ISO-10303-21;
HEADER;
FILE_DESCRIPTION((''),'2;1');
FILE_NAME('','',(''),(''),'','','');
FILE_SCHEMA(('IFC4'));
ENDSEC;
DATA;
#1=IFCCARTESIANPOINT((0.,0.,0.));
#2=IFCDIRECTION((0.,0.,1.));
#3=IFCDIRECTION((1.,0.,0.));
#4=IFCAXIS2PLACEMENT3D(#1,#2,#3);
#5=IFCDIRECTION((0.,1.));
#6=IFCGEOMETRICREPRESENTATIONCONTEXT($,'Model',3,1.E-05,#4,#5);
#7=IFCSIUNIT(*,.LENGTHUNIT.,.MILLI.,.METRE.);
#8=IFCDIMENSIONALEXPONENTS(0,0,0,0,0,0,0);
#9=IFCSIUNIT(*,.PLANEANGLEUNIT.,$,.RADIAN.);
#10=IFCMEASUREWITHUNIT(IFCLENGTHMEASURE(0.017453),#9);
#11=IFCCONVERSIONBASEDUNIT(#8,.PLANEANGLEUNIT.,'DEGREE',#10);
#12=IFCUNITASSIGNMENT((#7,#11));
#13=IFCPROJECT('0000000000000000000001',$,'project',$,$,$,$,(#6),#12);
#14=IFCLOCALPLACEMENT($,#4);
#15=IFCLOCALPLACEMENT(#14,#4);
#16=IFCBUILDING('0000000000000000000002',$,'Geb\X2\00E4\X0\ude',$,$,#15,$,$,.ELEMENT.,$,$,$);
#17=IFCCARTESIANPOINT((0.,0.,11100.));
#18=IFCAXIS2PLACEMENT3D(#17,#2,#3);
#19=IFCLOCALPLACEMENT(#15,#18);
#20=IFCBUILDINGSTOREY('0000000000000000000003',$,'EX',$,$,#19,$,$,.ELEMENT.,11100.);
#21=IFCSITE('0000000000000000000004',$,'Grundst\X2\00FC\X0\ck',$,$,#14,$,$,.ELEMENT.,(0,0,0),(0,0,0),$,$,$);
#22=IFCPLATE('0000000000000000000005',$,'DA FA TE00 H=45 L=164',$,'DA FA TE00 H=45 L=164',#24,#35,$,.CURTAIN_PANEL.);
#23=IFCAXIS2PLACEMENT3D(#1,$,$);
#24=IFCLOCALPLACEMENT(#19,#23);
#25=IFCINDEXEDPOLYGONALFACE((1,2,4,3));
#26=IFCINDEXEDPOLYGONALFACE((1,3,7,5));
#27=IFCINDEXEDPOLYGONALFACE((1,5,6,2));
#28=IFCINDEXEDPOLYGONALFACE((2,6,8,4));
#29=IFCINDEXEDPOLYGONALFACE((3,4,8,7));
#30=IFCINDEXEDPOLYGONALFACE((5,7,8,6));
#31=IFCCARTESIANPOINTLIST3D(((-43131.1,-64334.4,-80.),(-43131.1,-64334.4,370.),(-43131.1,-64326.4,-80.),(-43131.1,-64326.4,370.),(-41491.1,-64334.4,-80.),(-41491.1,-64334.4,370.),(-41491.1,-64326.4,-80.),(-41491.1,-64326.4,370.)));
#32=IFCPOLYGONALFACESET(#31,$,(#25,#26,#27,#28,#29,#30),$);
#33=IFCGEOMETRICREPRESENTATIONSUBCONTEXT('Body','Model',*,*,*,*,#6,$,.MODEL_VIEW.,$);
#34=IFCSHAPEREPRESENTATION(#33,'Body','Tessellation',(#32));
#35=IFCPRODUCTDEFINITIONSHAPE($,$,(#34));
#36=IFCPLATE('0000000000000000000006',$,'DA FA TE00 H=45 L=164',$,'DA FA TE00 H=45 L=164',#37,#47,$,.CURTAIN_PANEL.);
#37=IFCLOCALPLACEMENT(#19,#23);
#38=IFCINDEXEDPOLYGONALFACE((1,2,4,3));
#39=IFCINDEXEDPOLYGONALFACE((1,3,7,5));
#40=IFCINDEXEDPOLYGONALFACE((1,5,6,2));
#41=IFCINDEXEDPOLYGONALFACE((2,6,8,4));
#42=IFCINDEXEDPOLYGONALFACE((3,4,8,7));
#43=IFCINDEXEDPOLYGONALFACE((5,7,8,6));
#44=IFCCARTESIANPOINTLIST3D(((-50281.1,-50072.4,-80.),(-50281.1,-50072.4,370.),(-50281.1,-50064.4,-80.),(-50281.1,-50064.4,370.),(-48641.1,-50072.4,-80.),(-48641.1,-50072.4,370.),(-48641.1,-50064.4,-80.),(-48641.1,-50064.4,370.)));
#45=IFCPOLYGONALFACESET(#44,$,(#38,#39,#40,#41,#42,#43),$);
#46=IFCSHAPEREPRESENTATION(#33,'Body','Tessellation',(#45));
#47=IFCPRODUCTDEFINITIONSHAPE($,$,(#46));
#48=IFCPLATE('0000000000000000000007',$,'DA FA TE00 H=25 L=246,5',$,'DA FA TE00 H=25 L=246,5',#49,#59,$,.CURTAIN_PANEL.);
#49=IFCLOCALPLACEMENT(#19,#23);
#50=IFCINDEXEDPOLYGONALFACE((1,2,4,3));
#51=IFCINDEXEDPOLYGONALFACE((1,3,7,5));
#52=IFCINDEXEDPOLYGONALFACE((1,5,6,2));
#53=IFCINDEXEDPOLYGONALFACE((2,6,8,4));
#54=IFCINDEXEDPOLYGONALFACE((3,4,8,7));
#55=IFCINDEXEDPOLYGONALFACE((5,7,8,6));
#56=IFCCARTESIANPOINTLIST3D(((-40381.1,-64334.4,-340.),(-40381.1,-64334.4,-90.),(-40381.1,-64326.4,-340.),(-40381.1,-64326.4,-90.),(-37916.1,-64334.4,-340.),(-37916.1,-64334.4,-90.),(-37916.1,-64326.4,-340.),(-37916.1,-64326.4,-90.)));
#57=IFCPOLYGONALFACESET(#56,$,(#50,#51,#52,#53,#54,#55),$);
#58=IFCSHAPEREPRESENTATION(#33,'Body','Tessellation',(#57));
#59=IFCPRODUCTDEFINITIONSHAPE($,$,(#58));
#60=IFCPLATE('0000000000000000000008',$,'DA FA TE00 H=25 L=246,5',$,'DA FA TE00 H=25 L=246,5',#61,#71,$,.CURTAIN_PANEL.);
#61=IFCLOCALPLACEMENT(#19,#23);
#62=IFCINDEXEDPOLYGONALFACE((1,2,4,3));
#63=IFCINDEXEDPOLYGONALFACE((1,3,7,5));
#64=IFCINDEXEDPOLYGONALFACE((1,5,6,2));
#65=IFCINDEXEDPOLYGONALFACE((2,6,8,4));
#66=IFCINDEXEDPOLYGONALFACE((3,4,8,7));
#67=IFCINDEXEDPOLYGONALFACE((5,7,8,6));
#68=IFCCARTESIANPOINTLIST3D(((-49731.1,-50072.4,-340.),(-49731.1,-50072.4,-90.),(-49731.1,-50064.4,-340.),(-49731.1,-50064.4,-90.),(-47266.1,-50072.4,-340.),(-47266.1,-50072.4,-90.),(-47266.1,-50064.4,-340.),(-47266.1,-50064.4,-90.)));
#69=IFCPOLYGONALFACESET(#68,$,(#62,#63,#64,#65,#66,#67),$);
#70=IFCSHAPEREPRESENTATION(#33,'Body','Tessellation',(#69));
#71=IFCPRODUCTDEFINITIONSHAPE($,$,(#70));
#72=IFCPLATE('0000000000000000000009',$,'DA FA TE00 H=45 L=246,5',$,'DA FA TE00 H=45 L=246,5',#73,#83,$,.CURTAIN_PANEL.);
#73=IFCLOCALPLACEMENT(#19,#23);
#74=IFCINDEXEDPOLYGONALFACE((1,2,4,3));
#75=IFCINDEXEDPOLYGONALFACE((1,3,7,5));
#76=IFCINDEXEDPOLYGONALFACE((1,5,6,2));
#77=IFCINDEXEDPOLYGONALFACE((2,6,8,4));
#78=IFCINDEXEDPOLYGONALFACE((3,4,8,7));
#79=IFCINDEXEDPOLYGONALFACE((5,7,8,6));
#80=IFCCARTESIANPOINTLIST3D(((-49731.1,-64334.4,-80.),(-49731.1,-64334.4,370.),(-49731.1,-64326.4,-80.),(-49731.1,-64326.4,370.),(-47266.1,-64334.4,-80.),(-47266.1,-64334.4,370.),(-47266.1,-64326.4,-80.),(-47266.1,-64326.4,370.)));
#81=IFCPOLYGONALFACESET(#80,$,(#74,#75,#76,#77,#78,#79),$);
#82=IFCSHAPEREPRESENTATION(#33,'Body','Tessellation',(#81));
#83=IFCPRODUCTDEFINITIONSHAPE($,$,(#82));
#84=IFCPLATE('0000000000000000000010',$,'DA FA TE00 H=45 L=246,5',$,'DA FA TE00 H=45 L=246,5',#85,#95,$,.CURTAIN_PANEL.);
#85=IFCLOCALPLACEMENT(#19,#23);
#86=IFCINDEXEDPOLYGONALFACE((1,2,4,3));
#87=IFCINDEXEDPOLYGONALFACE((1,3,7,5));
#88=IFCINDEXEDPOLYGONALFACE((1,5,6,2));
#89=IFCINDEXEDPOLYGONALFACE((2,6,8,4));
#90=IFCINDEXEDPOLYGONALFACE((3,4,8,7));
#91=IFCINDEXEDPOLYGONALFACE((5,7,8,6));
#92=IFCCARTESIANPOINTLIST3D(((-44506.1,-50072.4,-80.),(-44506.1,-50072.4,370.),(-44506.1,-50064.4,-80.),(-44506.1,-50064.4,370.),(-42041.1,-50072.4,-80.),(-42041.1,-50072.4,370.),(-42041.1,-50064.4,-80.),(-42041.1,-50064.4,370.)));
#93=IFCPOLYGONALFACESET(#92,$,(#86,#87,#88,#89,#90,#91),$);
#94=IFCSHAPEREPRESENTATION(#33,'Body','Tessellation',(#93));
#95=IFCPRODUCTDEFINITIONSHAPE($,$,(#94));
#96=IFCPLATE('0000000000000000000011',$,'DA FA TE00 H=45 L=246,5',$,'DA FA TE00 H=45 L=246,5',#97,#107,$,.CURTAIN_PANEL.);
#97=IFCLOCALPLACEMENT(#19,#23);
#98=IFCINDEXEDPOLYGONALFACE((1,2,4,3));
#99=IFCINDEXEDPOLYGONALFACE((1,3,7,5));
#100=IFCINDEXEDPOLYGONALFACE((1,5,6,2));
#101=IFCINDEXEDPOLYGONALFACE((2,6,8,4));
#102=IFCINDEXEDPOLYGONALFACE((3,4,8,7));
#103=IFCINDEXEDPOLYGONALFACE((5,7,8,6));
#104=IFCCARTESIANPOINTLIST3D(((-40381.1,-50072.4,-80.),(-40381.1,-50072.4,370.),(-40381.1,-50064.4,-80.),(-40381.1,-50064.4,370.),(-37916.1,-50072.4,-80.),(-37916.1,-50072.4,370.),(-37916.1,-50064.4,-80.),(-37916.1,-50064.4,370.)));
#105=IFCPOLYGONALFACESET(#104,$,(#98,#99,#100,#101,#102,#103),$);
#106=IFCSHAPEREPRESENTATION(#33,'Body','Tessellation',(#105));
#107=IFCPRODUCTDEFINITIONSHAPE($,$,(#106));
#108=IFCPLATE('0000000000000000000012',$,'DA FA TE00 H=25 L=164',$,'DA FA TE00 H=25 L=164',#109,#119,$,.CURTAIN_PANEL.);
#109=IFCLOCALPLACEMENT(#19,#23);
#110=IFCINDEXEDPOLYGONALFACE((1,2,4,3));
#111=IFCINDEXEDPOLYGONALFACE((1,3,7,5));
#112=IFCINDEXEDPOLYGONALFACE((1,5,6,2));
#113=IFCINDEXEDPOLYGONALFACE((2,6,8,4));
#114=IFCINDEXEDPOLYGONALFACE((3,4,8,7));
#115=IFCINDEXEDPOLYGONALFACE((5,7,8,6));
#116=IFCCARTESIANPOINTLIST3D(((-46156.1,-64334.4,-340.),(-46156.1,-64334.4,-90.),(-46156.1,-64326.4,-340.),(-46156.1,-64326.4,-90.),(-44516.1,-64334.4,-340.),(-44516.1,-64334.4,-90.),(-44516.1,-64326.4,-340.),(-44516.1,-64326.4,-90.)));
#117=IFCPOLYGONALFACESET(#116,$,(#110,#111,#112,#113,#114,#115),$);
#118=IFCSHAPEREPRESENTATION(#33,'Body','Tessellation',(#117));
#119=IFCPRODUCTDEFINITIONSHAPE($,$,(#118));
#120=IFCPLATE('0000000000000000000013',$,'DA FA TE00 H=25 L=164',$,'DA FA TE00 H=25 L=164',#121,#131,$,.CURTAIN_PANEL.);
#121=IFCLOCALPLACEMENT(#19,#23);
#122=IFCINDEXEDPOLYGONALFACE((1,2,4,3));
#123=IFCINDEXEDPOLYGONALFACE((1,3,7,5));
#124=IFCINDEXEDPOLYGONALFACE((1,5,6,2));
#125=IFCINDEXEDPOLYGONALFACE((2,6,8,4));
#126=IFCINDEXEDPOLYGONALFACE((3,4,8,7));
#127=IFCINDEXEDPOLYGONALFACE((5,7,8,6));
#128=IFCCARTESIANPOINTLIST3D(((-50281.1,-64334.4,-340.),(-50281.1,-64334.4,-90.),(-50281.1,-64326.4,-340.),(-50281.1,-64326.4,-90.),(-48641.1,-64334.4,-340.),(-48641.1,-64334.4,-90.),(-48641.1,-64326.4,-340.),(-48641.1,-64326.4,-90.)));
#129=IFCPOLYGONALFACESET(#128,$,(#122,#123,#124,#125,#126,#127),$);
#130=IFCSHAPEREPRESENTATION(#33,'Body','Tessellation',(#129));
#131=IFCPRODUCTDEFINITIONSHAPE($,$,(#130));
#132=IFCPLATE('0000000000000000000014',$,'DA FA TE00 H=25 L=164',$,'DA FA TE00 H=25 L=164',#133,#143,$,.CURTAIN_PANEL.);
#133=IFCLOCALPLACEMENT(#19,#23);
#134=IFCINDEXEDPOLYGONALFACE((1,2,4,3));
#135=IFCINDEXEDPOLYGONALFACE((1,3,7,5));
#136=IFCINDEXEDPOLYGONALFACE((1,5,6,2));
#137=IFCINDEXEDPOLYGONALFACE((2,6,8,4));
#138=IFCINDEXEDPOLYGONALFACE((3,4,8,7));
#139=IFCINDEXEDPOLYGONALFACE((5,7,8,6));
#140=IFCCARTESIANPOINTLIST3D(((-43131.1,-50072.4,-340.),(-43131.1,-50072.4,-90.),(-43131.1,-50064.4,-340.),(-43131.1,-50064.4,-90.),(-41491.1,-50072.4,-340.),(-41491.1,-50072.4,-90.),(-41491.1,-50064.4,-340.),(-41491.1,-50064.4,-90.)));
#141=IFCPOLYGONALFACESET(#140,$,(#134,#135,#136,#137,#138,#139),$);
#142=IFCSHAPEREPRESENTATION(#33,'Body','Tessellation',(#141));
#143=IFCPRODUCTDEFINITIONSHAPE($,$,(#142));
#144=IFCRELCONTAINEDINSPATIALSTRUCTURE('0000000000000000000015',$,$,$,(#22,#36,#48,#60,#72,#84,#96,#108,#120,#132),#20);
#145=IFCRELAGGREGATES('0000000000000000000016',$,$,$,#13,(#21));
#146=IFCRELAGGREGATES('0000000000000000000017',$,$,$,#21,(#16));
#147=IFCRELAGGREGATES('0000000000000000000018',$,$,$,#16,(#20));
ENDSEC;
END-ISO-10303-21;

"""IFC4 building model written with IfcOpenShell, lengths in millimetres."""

from ifc_helpers import new_model, entity, si_unit, converted_unit, direction, frame, origin_with_axes, place, context, subcontext, project, spatial, line, indexed_curve, outline, extrude, source, transform, mapped, element, save


model = new_model("IFC4")

# Units and contexts
model_context = context("Model", 3, precision=1e-05, world=origin_with_axes(), true_north=direction((0.0, 1.0)))
body_context = subcontext(model_context, "Body", "Model", "MODEL_VIEW")
ifc_project = project(units=[si_unit("LENGTHUNIT", "METRE", prefix="MILLI"), converted_unit("PLANEANGLEUNIT", "DEGREE", entity("IfcLengthMeasure", 0.017453), si_unit("PLANEANGLEUNIT", "RADIAN"), dimensions=[0, 0, 0, 0, 0, 0, 0])], contexts=[model_context])

# Site, building, storey
site_placement = place(None, origin_with_axes())
site = spatial("IfcSite", under=ifc_project, at=site_placement, Name="Grundstück", CompositionType="ELEMENT", RefLatitude=(0, 0, 0), RefLongitude=(0, 0, 0))
building_placement = place(site_placement, origin_with_axes())
building = spatial("IfcBuilding", under=site, at=building_placement, Name="Gebäude", CompositionType="ELEMENT")
storey_placement = place(building_placement, frame((0.0, 0.0, 11100.0), z_axis=(0.0, 0.0, 1.0), x_axis=(1.0, 0.0, 0.0)))
storey = spatial("IfcBuildingStorey", under=building, at=storey_placement, Name="EX", CompositionType="ELEMENT", Elevation=11100.0)

# Plates
shared_shape_1 = source(origin_with_axes(), body_context, "Body", "SweptSolid", [
    extrude(outline(indexed_curve([(-820.0, 0.0), (820.0, 0.0), (820.0, 8.0), (-820.0, 8.0)], segments=[line(1, 2), line(2, 3), line(3, 4), line(4, 1)])), frame((0.0, 0.0, 450.0), z_axis=(0.0, 0.0, 1.0), x_axis=(1.0, 0.0, 0.0)), (0.0, 0.0, -1.0), 450.0),
])
for number, where, z_axis, x_axis, name in (
    (1, (-42311.1, -64334.4, -80.0), (0.0, 0.0, 1.0), (1.0, 0.0, 0.0), "DA FA TE00 H=45 L=164"),
    (2, (-49461.1, -50064.4, -80.0), (0.0, 0.0, 1.0), (-1.0, 0.0, 0.0), "DA FA TE00 H=45 L=164"),
):
    element("IfcPlate", number, at=place(storey_placement, frame(where, z_axis=z_axis, x_axis=x_axis)), inside=storey, Name=name, ObjectType="DA FA TE00 H=45 L=164", PredefinedType="CURTAIN_PANEL", context=body_context, shape_type="MappedRepresentation", body=[
        mapped(shared_shape_1, transform((0.0, 0.0, 0.0), x_axis=(1.0, 0.0, 0.0), y_axis=(0.0, 1.0, 0.0), z_axis=(0.0, 0.0, 1.0), scale=1.0)),
    ])
shared_shape_2 = source(origin_with_axes(), body_context, "Body", "SweptSolid", [
    extrude(outline(indexed_curve([(-1232.5, 0.0), (1232.5, 0.0), (1232.5, 8.0), (-1232.5, 8.0)], segments=[line(1, 2), line(2, 3), line(3, 4), line(4, 1)])), frame((0.0, 0.0, 250.0), z_axis=(0.0, 0.0, 1.0), x_axis=(1.0, 0.0, 0.0)), (0.0, 0.0, -1.0), 250.0),
])
for number, where, z_axis, x_axis, name in (
    (3, (-39148.6, -64334.4, -340.0), (0.0, 0.0, 1.0), (1.0, 0.0, 0.0), "DA FA TE00 H=25 L=246,5"),
    (4, (-48498.6, -50064.4, -340.0), (0.0, 0.0, 1.0), (-1.0, 0.0, 0.0), "DA FA TE00 H=25 L=246,5"),
):
    element("IfcPlate", number, at=place(storey_placement, frame(where, z_axis=z_axis, x_axis=x_axis)), inside=storey, Name=name, ObjectType="DA FA TE00 H=25 L=246,5", PredefinedType="CURTAIN_PANEL", context=body_context, shape_type="MappedRepresentation", body=[
        mapped(shared_shape_2, transform((0.0, 0.0, 0.0), x_axis=(1.0, 0.0, 0.0), y_axis=(0.0, 1.0, 0.0), z_axis=(0.0, 0.0, 1.0), scale=1.0)),
    ])
shared_shape_3 = source(origin_with_axes(), body_context, "Body", "SweptSolid", [
    extrude(outline(indexed_curve([(-1232.5, 0.0), (1232.5, 0.0), (1232.5, 8.0), (-1232.5, 8.0)], segments=[line(1, 2), line(2, 3), line(3, 4), line(4, 1)])), frame((0.0, 0.0, 450.0), z_axis=(0.0, 0.0, 1.0), x_axis=(1.0, 0.0, 0.0)), (0.0, 0.0, -1.0), 450.0),
])
for number, where, z_axis, x_axis, name in (
    (5, (-48498.6, -64334.4, -80.0), (0.0, 0.0, 1.0), (1.0, 0.0, 0.0), "DA FA TE00 H=45 L=246,5"),
    (6, (-43273.6, -50064.4, -80.0), (0.0, 0.0, 1.0), (-1.0, 0.0, 0.0), "DA FA TE00 H=45 L=246,5"),
    (7, (-39148.6, -50064.4, -80.0), (0.0, 0.0, 1.0), (-1.0, 0.0, 0.0), "DA FA TE00 H=45 L=246,5"),
):
    element("IfcPlate", number, at=place(storey_placement, frame(where, z_axis=z_axis, x_axis=x_axis)), inside=storey, Name=name, ObjectType="DA FA TE00 H=45 L=246,5", PredefinedType="CURTAIN_PANEL", context=body_context, shape_type="MappedRepresentation", body=[
        mapped(shared_shape_3, transform((0.0, 0.0, 0.0), x_axis=(1.0, 0.0, 0.0), y_axis=(0.0, 1.0, 0.0), z_axis=(0.0, 0.0, 1.0), scale=1.0)),
    ])
shared_shape_4 = source(origin_with_axes(), body_context, "Body", "SweptSolid", [
    extrude(outline(indexed_curve([(-820.0, 0.0), (820.0, 0.0), (820.0, 8.0), (-820.0, 8.0)], segments=[line(1, 2), line(2, 3), line(3, 4), line(4, 1)])), frame((0.0, 0.0, 250.0), z_axis=(0.0, 0.0, 1.0), x_axis=(1.0, 0.0, 0.0)), (0.0, 0.0, -1.0), 250.0),
])
for number, where, z_axis, x_axis, name in (
    (8, (-45336.1, -64334.4, -340.0), (0.0, 0.0, 1.0), (1.0, 0.0, 0.0), "DA FA TE00 H=25 L=164"),
    (9, (-49461.1, -64334.4, -340.0), (0.0, 0.0, 1.0), (1.0, 0.0, 0.0), "DA FA TE00 H=25 L=164"),
    (10, (-42311.1, -50064.4, -340.0), (0.0, 0.0, 1.0), (-1.0, 0.0, 0.0), "DA FA TE00 H=25 L=164"),
):
    element("IfcPlate", number, at=place(storey_placement, frame(where, z_axis=z_axis, x_axis=x_axis)), inside=storey, Name=name, ObjectType="DA FA TE00 H=25 L=164", PredefinedType="CURTAIN_PANEL", context=body_context, shape_type="MappedRepresentation", body=[
        mapped(shared_shape_4, transform((0.0, 0.0, 0.0), x_axis=(1.0, 0.0, 0.0), y_axis=(0.0, 1.0, 0.0), z_axis=(0.0, 0.0, 1.0), scale=1.0)),
    ])

save(model, "model.ifc")
